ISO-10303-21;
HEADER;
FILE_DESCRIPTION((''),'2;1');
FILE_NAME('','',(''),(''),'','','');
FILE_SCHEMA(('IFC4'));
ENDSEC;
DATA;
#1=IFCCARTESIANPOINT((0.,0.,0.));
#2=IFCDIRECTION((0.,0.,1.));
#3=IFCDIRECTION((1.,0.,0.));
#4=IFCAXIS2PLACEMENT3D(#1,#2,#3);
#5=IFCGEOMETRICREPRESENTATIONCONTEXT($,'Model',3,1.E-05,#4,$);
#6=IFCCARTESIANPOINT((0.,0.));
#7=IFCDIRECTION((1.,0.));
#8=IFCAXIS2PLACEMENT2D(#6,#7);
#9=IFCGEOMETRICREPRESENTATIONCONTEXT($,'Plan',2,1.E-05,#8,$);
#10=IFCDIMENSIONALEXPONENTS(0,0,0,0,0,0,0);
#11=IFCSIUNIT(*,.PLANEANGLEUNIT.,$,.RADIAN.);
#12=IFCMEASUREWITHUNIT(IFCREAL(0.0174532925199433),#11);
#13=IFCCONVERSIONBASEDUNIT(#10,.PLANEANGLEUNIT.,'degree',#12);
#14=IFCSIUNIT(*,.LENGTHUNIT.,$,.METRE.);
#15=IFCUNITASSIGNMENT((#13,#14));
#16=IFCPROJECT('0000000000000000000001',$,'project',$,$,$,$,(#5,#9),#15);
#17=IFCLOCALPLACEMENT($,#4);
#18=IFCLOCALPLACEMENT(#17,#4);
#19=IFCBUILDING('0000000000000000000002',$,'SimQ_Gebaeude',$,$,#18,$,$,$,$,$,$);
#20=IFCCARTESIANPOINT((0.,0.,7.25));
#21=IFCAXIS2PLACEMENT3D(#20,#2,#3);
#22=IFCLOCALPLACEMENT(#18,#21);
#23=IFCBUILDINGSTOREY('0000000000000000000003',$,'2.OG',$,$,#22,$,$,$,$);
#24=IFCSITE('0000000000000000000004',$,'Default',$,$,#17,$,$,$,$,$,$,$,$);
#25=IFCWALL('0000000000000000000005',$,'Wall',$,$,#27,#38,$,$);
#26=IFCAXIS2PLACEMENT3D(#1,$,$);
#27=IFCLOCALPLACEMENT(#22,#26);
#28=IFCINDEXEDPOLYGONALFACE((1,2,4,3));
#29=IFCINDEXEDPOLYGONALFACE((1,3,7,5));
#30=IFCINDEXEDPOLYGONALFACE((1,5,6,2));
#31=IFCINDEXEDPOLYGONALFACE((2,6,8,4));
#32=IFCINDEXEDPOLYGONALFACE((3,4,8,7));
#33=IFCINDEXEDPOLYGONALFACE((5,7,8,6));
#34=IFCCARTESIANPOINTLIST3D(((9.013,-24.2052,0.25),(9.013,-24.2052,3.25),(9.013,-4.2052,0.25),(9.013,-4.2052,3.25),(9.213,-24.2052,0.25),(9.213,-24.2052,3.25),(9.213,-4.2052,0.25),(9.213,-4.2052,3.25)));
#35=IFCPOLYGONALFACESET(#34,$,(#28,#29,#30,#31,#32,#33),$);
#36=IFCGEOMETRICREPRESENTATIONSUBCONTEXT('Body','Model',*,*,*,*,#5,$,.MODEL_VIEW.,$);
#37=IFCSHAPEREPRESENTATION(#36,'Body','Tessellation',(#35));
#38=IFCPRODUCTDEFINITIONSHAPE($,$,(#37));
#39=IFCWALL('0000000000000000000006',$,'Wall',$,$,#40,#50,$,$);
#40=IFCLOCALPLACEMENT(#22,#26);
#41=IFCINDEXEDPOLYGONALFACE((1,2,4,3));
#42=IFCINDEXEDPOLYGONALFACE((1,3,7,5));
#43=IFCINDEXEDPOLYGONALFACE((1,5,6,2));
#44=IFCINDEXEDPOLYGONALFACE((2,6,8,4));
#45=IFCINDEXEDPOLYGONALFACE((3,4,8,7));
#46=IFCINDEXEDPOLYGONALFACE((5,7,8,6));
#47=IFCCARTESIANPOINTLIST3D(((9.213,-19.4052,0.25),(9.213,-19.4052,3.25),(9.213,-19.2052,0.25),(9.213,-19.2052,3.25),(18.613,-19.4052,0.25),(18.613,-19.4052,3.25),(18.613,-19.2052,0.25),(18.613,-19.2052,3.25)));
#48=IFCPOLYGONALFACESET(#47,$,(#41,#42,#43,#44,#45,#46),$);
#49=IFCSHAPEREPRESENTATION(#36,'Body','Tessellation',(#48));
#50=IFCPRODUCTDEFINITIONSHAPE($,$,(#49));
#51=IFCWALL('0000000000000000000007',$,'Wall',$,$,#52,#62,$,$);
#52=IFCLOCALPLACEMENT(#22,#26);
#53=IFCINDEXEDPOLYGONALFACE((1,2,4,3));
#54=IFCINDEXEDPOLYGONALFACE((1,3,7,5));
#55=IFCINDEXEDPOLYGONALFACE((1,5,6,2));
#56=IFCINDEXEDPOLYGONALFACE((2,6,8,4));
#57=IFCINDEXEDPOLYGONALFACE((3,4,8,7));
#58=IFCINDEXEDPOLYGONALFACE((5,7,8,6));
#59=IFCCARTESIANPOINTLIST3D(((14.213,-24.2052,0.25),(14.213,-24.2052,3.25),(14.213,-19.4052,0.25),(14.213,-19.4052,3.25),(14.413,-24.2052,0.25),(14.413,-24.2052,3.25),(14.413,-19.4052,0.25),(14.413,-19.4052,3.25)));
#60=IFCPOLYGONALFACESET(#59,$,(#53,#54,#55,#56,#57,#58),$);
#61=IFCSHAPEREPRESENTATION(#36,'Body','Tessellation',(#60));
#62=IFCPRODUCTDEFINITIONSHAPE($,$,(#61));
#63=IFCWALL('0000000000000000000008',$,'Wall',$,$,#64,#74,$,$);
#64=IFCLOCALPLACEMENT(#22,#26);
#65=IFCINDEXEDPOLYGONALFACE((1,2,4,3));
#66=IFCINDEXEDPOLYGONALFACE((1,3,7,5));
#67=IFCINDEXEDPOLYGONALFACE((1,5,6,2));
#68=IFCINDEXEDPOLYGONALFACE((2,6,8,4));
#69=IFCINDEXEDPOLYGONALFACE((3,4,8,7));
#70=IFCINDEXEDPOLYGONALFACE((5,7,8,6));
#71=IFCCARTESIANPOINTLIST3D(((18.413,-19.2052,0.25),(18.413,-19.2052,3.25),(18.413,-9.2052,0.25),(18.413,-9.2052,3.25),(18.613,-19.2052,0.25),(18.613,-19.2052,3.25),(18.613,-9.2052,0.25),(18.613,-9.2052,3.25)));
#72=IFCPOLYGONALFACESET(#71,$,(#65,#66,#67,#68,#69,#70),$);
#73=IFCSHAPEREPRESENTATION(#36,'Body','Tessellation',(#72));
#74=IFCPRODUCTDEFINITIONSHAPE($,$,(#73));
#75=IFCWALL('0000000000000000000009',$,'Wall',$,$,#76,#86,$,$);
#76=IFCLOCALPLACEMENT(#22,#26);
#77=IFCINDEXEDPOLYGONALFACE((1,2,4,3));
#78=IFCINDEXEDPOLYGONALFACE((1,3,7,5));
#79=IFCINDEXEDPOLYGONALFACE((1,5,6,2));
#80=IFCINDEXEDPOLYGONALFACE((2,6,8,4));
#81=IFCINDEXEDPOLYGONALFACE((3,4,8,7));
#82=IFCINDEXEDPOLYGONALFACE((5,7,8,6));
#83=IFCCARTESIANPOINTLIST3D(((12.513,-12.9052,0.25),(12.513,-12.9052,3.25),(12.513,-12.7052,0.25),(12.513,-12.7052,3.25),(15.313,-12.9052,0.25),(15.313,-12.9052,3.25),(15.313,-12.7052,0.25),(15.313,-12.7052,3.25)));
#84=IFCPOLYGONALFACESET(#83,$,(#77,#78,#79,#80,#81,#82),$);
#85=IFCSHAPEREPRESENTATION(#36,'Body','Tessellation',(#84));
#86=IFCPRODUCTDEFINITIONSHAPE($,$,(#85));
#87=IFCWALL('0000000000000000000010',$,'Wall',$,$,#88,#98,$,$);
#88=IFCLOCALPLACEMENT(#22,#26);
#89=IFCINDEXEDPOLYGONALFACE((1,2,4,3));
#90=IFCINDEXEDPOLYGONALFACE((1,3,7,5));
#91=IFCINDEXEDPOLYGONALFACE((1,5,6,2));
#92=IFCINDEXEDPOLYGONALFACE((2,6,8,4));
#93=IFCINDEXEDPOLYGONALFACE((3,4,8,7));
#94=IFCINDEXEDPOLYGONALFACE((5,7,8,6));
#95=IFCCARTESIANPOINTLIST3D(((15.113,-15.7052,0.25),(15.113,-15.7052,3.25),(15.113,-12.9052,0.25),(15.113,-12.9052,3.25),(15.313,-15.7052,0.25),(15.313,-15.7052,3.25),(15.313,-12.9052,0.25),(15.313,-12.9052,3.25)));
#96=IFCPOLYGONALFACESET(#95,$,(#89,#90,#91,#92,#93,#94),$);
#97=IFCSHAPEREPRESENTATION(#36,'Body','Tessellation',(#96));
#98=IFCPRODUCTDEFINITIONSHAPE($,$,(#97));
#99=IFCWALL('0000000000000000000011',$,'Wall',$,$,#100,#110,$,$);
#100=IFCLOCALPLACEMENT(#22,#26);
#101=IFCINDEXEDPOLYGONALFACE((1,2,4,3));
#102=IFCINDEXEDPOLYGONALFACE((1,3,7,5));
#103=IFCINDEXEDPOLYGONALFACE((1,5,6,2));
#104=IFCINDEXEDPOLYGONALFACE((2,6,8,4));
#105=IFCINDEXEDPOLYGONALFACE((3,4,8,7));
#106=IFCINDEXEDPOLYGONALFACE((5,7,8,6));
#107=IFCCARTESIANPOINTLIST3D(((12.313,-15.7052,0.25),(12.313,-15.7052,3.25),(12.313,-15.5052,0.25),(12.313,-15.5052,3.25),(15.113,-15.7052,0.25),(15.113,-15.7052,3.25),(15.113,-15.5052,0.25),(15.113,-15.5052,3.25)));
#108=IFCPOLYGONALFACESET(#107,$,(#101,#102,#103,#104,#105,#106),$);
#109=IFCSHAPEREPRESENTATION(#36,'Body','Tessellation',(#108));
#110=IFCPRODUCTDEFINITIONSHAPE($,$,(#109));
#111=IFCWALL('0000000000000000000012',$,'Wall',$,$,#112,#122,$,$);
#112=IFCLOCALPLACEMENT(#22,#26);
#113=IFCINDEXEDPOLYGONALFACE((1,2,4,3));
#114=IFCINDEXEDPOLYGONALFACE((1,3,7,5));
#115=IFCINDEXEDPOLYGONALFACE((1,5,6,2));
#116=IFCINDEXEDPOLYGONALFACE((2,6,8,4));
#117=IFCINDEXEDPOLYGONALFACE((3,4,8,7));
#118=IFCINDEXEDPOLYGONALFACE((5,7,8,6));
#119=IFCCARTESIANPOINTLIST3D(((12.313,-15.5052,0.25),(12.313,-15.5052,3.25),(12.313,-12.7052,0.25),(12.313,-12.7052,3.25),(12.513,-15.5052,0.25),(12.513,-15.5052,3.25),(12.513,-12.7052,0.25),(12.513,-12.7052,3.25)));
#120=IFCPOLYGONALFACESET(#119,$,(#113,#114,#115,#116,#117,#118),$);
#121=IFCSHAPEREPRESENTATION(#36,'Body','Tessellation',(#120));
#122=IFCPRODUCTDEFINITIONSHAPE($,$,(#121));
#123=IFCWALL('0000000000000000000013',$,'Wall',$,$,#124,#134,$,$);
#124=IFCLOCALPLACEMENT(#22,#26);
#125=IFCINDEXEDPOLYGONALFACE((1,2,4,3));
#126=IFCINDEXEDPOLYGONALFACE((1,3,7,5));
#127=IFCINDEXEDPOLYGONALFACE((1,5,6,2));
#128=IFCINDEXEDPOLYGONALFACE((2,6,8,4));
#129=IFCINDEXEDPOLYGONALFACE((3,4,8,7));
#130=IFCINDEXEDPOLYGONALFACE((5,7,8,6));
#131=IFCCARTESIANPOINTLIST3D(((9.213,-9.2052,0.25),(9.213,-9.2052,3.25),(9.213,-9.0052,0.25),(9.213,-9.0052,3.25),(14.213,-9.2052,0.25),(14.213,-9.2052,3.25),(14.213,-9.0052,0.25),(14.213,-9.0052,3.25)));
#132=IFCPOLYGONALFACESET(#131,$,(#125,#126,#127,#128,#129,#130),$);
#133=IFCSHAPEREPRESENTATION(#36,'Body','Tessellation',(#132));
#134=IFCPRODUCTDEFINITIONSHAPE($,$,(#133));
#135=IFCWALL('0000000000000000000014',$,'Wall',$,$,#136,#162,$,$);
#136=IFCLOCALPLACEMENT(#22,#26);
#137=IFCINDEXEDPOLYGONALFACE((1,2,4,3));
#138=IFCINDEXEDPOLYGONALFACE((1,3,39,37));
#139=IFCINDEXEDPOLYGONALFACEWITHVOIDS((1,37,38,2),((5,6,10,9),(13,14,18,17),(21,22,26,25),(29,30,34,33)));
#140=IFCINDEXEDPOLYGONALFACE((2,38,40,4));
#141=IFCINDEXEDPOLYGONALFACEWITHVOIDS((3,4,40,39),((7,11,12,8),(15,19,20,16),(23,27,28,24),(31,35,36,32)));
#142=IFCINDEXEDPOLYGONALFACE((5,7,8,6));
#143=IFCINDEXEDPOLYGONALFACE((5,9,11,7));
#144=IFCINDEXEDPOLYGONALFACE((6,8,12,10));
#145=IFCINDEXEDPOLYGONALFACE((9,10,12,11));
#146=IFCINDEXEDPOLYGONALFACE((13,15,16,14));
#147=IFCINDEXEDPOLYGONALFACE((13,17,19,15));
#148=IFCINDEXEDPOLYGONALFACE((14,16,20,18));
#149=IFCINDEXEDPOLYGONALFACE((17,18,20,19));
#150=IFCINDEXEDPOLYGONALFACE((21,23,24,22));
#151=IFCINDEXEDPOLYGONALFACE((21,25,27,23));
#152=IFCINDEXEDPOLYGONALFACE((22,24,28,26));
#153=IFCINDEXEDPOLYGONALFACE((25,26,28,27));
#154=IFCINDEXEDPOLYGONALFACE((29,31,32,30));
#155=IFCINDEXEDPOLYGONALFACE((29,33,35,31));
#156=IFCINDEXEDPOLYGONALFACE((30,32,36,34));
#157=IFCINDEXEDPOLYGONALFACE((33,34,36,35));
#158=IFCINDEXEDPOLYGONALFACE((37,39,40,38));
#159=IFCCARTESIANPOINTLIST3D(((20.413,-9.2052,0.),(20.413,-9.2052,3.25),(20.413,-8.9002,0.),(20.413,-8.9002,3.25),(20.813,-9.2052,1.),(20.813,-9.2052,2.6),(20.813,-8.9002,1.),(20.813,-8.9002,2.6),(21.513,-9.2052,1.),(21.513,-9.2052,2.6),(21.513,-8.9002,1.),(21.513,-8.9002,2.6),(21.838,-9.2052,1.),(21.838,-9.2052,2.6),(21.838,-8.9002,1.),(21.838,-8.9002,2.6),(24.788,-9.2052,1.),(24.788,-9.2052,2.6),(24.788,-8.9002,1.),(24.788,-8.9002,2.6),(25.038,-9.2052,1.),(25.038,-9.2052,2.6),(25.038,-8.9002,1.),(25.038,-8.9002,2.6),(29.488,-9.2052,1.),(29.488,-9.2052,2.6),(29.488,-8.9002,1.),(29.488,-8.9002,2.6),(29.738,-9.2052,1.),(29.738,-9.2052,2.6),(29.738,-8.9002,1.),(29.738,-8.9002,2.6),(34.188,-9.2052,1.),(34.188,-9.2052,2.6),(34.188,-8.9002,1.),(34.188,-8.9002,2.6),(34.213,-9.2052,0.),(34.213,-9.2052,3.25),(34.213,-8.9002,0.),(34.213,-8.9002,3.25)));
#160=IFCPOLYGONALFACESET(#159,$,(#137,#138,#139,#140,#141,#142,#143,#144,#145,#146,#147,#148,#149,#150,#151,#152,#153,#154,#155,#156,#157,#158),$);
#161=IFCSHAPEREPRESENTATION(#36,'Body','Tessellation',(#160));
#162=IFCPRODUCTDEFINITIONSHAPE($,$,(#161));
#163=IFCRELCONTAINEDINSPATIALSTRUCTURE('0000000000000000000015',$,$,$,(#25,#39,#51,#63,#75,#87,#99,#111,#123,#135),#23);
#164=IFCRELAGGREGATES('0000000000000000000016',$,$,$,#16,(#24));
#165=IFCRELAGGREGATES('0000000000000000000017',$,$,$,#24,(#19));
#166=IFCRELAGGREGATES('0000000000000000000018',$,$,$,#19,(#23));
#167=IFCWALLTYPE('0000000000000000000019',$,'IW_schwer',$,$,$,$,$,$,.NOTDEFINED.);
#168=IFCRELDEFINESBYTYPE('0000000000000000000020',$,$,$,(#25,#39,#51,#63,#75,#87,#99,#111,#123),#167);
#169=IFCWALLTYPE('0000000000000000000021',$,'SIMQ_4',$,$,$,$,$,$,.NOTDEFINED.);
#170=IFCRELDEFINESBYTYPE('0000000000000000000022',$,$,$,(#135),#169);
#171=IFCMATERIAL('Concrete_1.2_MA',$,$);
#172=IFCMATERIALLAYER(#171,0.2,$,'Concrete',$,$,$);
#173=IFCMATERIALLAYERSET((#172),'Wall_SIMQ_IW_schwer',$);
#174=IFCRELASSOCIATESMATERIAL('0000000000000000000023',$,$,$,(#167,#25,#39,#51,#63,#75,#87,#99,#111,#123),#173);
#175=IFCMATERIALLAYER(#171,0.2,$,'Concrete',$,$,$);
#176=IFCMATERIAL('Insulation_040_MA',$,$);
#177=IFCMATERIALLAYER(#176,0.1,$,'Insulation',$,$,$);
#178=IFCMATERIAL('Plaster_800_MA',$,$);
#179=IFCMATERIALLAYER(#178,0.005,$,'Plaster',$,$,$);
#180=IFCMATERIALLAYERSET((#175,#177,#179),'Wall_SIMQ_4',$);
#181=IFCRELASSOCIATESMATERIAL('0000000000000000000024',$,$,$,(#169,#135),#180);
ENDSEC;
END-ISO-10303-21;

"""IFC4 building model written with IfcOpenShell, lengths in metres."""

from ifc_helpers import new_model, entity, si_unit, converted_unit, frame, origin_with_axes, origin_2d_with_axis, place, context, subcontext, project, spatial, line, indexed_curve, outline, extrude, source, transform, mapped, material, layer, layer_set, layer_usage, type_object, element, save


model = new_model("IFC4")

# Units and contexts
model_context = context("Model", 3, precision=1e-05, world=origin_with_axes())
plan_context = context("Plan", 2, precision=1e-05, world=origin_2d_with_axis())
body_context = subcontext(model_context, "Body", "Model", "MODEL_VIEW")
ifc_project = project(units=[converted_unit("PLANEANGLEUNIT", "degree", entity("IfcReal", 0.0174532925199433), si_unit("PLANEANGLEUNIT", "RADIAN"), dimensions=[0, 0, 0, 0, 0, 0, 0]), si_unit("LENGTHUNIT", "METRE")], contexts=[model_context, plan_context])

# Site, building, storey
site_placement = place(None, origin_with_axes())
site = spatial("IfcSite", under=ifc_project, at=site_placement, Name="Default")
building_placement = place(site_placement, origin_with_axes())
building = spatial("IfcBuilding", under=site, at=building_placement, Name="SimQ_Gebaeude")
storey_placement = place(building_placement, frame((0.0, 0.0, 7.25), z_axis=(0.0, 0.0, 1.0), x_axis=(1.0, 0.0, 0.0)))
storey = spatial("IfcBuildingStorey", under=building, at=storey_placement, Name="2.OG")

# Shared definitions
ifc_material_1 = material(Name="Insulation_040_MA")
ifc_material_2 = material(Name="Concrete_1.2_MA")

# Walls
ifc_layer_1 = layer(ifc_material_2, 0.2, Name="Concrete")
ifc_layer_set_1 = layer_set([ifc_layer_1], Name="Wall_SIMQ_IW_schwer")
ifc_layer_usage_1 = layer_usage(ifc_layer_set_1, "AXIS2", "POSITIVE", 0.0)
wall_type_1 = type_object("IfcWallType", Name="IW_schwer", PredefinedType="NOTDEFINED", material=ifc_layer_set_1)
wall_1_placement = place(storey_placement, frame((9.213, -24.2052, 0.25), z_axis=(0.0, 0.0, 1.0), x_axis=(0.000001, 1.0, 0.0)))
element("IfcWall", 1, at=wall_1_placement, inside=storey, type_object=wall_type_1, material=ifc_layer_usage_1, Name="Wall", context=body_context, shape_type="SweptSolid", body=[
    extrude(outline(indexed_curve([(0.0, 0.0), (0.0, 0.2), (20.0, 0.2), (20.0, 0.0), (0.0, 0.0)], self_intersect=False)), origin_with_axes(), (0.0, 0.0, 1.0), 3.0),
])
ifc_layer_usage_2 = layer_usage(ifc_layer_set_1, "AXIS2", "POSITIVE", 0.0)
wall_2_placement = place(storey_placement, frame((18.613, -19.2052, 0.25), z_axis=(0.0, 0.0, 1.0), x_axis=(-1.0, 0.0, 0.0)))
element("IfcWall", 2, at=wall_2_placement, inside=storey, type_object=wall_type_1, material=ifc_layer_usage_2, Name="Wall", context=body_context, shape_type="SweptSolid", body=[
    extrude(outline(indexed_curve([(0.0, 0.0), (0.0, 0.2), (9.4, 0.2), (9.4, 0.0), (0.0, 0.0)], self_intersect=False)), origin_with_axes(), (0.0, 0.0, 1.0), 3.0),
])
ifc_layer_usage_3 = layer_usage(ifc_layer_set_1, "AXIS2", "POSITIVE", 0.0)
wall_3_placement = place(storey_placement, frame((14.213, -19.4052, 0.25), z_axis=(0.0, 0.0, 1.0), x_axis=(-0.000001, -1.0, 0.0)))
element("IfcWall", 3, at=wall_3_placement, inside=storey, type_object=wall_type_1, material=ifc_layer_usage_3, Name="Wall", context=body_context, shape_type="SweptSolid", body=[
    extrude(outline(indexed_curve([(0.0, 0.0), (0.0, 0.2), (4.8, 0.2), (4.8, 0.0), (0.0, 0.0)], self_intersect=False)), origin_with_axes(), (0.0, 0.0, 1.0), 3.0),
])
ifc_layer_usage_4 = layer_usage(ifc_layer_set_1, "AXIS2", "POSITIVE", 0.0)
wall_4_placement = place(storey_placement, frame((18.613, -19.2052, 0.25), z_axis=(0.0, 0.0, 1.0), x_axis=(0.000001, 1.0, 0.0)))
element("IfcWall", 4, at=wall_4_placement, inside=storey, type_object=wall_type_1, material=ifc_layer_usage_4, Name="Wall", context=body_context, shape_type="SweptSolid", body=[
    extrude(outline(indexed_curve([(0.0, 0.0), (0.0, 0.2), (10.0, 0.2), (10.0, 0.0), (0.0, 0.0)], self_intersect=False)), origin_with_axes(), (0.0, 0.0, 1.0), 3.0),
])
ifc_layer_usage_5 = layer_usage(ifc_layer_set_1, "AXIS2", "POSITIVE", 0.0)
wall_5_placement = place(storey_placement, frame((15.313, -12.7052, 0.25), z_axis=(0.0, 0.0, 1.0), x_axis=(-1.0, 0.0, 0.0)))
element("IfcWall", 5, at=wall_5_placement, inside=storey, type_object=wall_type_1, material=ifc_layer_usage_5, Name="Wall", context=body_context, shape_type="SweptSolid", body=[
    extrude(outline(indexed_curve([(0.0, 0.0), (0.0, 0.2), (2.8, 0.2), (2.8, 0.0), (0.0, 0.0)], self_intersect=False)), origin_with_axes(), (0.0, 0.0, 1.0), 3.0),
])
ifc_layer_usage_6 = layer_usage(ifc_layer_set_1, "AXIS2", "POSITIVE", 0.0)
wall_6_placement = place(storey_placement, frame((15.113, -12.9052, 0.25), z_axis=(0.0, 0.0, 1.0), x_axis=(-0.000001, -1.0, 0.0)))
element("IfcWall", 6, at=wall_6_placement, inside=storey, type_object=wall_type_1, material=ifc_layer_usage_6, Name="Wall", context=body_context, shape_type="SweptSolid", body=[
    extrude(outline(indexed_curve([(0.0, 0.0), (0.0, 0.2), (2.8, 0.2), (2.8, 0.0), (0.0, 0.0)], self_intersect=False)), origin_with_axes(), (0.0, 0.0, 1.0), 3.0),
])
ifc_layer_usage_7 = layer_usage(ifc_layer_set_1, "AXIS2", "POSITIVE", 0.0)
wall_7_placement = place(storey_placement, frame((15.113, -15.5052, 0.25), z_axis=(0.0, 0.0, 1.0), x_axis=(-1.0, 0.0, 0.0)))
element("IfcWall", 7, at=wall_7_placement, inside=storey, type_object=wall_type_1, material=ifc_layer_usage_7, Name="Wall", context=body_context, shape_type="SweptSolid", body=[
    extrude(outline(indexed_curve([(0.0, 0.0), (0.0, 0.2), (2.8, 0.2), (2.8, 0.0), (0.0, 0.0)], self_intersect=False)), origin_with_axes(), (0.0, 0.0, 1.0), 3.0),
])
ifc_layer_usage_8 = layer_usage(ifc_layer_set_1, "AXIS2", "POSITIVE", 0.0)
wall_8_placement = place(storey_placement, frame((12.513, -15.5052, 0.25), z_axis=(0.0, 0.0, 1.0), x_axis=(0.000001, 1.0, 0.0)))
element("IfcWall", 8, at=wall_8_placement, inside=storey, type_object=wall_type_1, material=ifc_layer_usage_8, Name="Wall", context=body_context, shape_type="SweptSolid", body=[
    extrude(outline(indexed_curve([(0.0, 0.0), (0.0, 0.2), (2.8, 0.2), (2.8, 0.0), (0.0, 0.0)], self_intersect=False)), origin_with_axes(), (0.0, 0.0, 1.0), 3.0),
])
ifc_layer_usage_9 = layer_usage(ifc_layer_set_1, "AXIS2", "POSITIVE", 0.0)
wall_9_placement = place(storey_placement, frame((9.213, -9.2052, 0.25), z_axis=(0.0, 0.0, 1.0), x_axis=(1.0, 0.0, 0.0)))
element("IfcWall", 9, at=wall_9_placement, inside=storey, type_object=wall_type_1, material=ifc_layer_usage_9, Name="Wall", context=body_context, shape_type="SweptSolid", body=[
    extrude(outline(indexed_curve([(0.0, 0.0), (0.0, 0.2), (5.0, 0.2), (5.0, 0.0), (0.0, 0.0)], self_intersect=False)), origin_with_axes(), (0.0, 0.0, 1.0), 3.0),
])

# Wall, openings
ifc_layer_2 = layer(ifc_material_2, 0.2, Name="Concrete")
ifc_layer_3 = layer(ifc_material_1, 0.1, Name="Insulation")
ifc_material_3 = material(Name="Plaster_800_MA")
ifc_layer_4 = layer(ifc_material_3, 0.005, Name="Plaster")
ifc_layer_set_2 = layer_set([ifc_layer_2, ifc_layer_3, ifc_layer_4], Name="Wall_SIMQ_4")
ifc_layer_usage_10 = layer_usage(ifc_layer_set_2, "AXIS2", "POSITIVE", 0.0)
wall_type_2 = type_object("IfcWallType", Name="SIMQ_4", PredefinedType="NOTDEFINED", material=ifc_layer_set_2)
wall_10_placement = place(storey_placement, frame((34.213, -8.9002, 0.0), z_axis=(0.0, 0.0, 1.0), x_axis=(-1.0, 0.0, 0.0)))
wall_10 = element("IfcWall", 10, at=wall_10_placement, inside=storey, type_object=wall_type_2, material=ifc_layer_usage_10, Name="Wall", context=body_context, shape_type="SweptSolid", body=[
    extrude(outline(indexed_curve([(0.0, 0.0), (0.0, 0.305), (13.8, 0.305), (13.8, 0.0), (0.0, 0.0)], self_intersect=False)), origin_with_axes(), (0.0, 0.0, 1.0), 3.25),
])
shared_shape_1 = source(origin_with_axes(), body_context, "Body", "SweptSolid", [
    extrude(outline(indexed_curve([(0.0, 0.0), (0.7, 0.0), (0.7, 1.6), (0.0, 1.6)], segments=[line(1, 2, 3, 4, 1)])), frame((0.0, -0.6, 0.0), z_axis=(0.0, -1.0, 0.0), x_axis=(1.0, 0.0, 0.0)), (0.0, 0.0, -1.0), 1.2),
])
opening_1_placement = place(wall_10_placement, frame((12.7, 0.0, 1.0), z_axis=(0.0, 0.0, 1.0), x_axis=(1.0, 0.0, 0.0)))
element("IfcOpeningElement", 11, at=opening_1_placement, cuts=wall_10, PredefinedType="OPENING", context=body_context, shape_type="MappedRepresentation", body=[
    mapped(shared_shape_1, transform((0.0, 0.0, 0.0), x_axis=(1.0, 0.0, 0.0), y_axis=(0.0, 1.0, 0.0), z_axis=(0.0, 0.0, 1.0), scale=1.0)),
])
shared_shape_2 = source(origin_with_axes(), body_context, "Body", "SweptSolid", [
    extrude(outline(indexed_curve([(0.0, 0.0), (2.95, 0.0), (2.95, 1.6), (0.0, 1.6)], segments=[line(1, 2, 3, 4, 1)])), frame((0.0, -0.6, 0.0), z_axis=(0.0, -1.0, 0.0), x_axis=(1.0, 0.0, 0.0)), (0.0, 0.0, -1.0), 1.2),
])
opening_2_placement = place(wall_10_placement, frame((9.425, 0.0, 1.0), z_axis=(0.0, 0.0, 1.0), x_axis=(1.0, 0.0, 0.0)))
element("IfcOpeningElement", 12, at=opening_2_placement, cuts=wall_10, PredefinedType="OPENING", context=body_context, shape_type="MappedRepresentation", body=[
    mapped(shared_shape_2, transform((0.0, 0.0, 0.0), x_axis=(1.0, 0.0, 0.0), y_axis=(0.0, 1.0, 0.0), z_axis=(0.0, 0.0, 1.0), scale=1.0)),
])
shared_shape_3 = source(origin_with_axes(), body_context, "Body", "SweptSolid", [
    extrude(outline(indexed_curve([(0.0, 0.0), (4.45, 0.0), (4.45, 1.6), (0.0, 1.6)], segments=[line(1, 2, 3, 4, 1)])), frame((0.0, -0.6, 0.0), z_axis=(0.0, -1.0, 0.0), x_axis=(1.0, 0.0, 0.0)), (0.0, 0.0, -1.0), 1.2),
])
opening_3_placement = place(wall_10_placement, frame((4.725, 0.0, 1.0), z_axis=(0.0, 0.0, 1.0), x_axis=(1.0, 0.0, 0.0)))
element("IfcOpeningElement", 13, at=opening_3_placement, cuts=wall_10, PredefinedType="OPENING", context=body_context, shape_type="MappedRepresentation", body=[
    mapped(shared_shape_3, transform((0.0, 0.0, 0.0), x_axis=(1.0, 0.0, 0.0), y_axis=(0.0, 1.0, 0.0), z_axis=(0.0, 0.0, 1.0), scale=1.0)),
])
opening_4_placement = place(wall_10_placement, frame((0.025, 0.0, 1.0), z_axis=(0.0, 0.0, 1.0), x_axis=(1.0, 0.0, 0.0)))
element("IfcOpeningElement", 14, at=opening_4_placement, cuts=wall_10, PredefinedType="OPENING", context=body_context, shape_type="MappedRepresentation", body=[
    mapped(shared_shape_3, transform((0.0, 0.0, 0.0), x_axis=(1.0, 0.0, 0.0), y_axis=(0.0, 1.0, 0.0), z_axis=(0.0, 0.0, 1.0), scale=1.0)),
])

save(model, "model.ifc")
